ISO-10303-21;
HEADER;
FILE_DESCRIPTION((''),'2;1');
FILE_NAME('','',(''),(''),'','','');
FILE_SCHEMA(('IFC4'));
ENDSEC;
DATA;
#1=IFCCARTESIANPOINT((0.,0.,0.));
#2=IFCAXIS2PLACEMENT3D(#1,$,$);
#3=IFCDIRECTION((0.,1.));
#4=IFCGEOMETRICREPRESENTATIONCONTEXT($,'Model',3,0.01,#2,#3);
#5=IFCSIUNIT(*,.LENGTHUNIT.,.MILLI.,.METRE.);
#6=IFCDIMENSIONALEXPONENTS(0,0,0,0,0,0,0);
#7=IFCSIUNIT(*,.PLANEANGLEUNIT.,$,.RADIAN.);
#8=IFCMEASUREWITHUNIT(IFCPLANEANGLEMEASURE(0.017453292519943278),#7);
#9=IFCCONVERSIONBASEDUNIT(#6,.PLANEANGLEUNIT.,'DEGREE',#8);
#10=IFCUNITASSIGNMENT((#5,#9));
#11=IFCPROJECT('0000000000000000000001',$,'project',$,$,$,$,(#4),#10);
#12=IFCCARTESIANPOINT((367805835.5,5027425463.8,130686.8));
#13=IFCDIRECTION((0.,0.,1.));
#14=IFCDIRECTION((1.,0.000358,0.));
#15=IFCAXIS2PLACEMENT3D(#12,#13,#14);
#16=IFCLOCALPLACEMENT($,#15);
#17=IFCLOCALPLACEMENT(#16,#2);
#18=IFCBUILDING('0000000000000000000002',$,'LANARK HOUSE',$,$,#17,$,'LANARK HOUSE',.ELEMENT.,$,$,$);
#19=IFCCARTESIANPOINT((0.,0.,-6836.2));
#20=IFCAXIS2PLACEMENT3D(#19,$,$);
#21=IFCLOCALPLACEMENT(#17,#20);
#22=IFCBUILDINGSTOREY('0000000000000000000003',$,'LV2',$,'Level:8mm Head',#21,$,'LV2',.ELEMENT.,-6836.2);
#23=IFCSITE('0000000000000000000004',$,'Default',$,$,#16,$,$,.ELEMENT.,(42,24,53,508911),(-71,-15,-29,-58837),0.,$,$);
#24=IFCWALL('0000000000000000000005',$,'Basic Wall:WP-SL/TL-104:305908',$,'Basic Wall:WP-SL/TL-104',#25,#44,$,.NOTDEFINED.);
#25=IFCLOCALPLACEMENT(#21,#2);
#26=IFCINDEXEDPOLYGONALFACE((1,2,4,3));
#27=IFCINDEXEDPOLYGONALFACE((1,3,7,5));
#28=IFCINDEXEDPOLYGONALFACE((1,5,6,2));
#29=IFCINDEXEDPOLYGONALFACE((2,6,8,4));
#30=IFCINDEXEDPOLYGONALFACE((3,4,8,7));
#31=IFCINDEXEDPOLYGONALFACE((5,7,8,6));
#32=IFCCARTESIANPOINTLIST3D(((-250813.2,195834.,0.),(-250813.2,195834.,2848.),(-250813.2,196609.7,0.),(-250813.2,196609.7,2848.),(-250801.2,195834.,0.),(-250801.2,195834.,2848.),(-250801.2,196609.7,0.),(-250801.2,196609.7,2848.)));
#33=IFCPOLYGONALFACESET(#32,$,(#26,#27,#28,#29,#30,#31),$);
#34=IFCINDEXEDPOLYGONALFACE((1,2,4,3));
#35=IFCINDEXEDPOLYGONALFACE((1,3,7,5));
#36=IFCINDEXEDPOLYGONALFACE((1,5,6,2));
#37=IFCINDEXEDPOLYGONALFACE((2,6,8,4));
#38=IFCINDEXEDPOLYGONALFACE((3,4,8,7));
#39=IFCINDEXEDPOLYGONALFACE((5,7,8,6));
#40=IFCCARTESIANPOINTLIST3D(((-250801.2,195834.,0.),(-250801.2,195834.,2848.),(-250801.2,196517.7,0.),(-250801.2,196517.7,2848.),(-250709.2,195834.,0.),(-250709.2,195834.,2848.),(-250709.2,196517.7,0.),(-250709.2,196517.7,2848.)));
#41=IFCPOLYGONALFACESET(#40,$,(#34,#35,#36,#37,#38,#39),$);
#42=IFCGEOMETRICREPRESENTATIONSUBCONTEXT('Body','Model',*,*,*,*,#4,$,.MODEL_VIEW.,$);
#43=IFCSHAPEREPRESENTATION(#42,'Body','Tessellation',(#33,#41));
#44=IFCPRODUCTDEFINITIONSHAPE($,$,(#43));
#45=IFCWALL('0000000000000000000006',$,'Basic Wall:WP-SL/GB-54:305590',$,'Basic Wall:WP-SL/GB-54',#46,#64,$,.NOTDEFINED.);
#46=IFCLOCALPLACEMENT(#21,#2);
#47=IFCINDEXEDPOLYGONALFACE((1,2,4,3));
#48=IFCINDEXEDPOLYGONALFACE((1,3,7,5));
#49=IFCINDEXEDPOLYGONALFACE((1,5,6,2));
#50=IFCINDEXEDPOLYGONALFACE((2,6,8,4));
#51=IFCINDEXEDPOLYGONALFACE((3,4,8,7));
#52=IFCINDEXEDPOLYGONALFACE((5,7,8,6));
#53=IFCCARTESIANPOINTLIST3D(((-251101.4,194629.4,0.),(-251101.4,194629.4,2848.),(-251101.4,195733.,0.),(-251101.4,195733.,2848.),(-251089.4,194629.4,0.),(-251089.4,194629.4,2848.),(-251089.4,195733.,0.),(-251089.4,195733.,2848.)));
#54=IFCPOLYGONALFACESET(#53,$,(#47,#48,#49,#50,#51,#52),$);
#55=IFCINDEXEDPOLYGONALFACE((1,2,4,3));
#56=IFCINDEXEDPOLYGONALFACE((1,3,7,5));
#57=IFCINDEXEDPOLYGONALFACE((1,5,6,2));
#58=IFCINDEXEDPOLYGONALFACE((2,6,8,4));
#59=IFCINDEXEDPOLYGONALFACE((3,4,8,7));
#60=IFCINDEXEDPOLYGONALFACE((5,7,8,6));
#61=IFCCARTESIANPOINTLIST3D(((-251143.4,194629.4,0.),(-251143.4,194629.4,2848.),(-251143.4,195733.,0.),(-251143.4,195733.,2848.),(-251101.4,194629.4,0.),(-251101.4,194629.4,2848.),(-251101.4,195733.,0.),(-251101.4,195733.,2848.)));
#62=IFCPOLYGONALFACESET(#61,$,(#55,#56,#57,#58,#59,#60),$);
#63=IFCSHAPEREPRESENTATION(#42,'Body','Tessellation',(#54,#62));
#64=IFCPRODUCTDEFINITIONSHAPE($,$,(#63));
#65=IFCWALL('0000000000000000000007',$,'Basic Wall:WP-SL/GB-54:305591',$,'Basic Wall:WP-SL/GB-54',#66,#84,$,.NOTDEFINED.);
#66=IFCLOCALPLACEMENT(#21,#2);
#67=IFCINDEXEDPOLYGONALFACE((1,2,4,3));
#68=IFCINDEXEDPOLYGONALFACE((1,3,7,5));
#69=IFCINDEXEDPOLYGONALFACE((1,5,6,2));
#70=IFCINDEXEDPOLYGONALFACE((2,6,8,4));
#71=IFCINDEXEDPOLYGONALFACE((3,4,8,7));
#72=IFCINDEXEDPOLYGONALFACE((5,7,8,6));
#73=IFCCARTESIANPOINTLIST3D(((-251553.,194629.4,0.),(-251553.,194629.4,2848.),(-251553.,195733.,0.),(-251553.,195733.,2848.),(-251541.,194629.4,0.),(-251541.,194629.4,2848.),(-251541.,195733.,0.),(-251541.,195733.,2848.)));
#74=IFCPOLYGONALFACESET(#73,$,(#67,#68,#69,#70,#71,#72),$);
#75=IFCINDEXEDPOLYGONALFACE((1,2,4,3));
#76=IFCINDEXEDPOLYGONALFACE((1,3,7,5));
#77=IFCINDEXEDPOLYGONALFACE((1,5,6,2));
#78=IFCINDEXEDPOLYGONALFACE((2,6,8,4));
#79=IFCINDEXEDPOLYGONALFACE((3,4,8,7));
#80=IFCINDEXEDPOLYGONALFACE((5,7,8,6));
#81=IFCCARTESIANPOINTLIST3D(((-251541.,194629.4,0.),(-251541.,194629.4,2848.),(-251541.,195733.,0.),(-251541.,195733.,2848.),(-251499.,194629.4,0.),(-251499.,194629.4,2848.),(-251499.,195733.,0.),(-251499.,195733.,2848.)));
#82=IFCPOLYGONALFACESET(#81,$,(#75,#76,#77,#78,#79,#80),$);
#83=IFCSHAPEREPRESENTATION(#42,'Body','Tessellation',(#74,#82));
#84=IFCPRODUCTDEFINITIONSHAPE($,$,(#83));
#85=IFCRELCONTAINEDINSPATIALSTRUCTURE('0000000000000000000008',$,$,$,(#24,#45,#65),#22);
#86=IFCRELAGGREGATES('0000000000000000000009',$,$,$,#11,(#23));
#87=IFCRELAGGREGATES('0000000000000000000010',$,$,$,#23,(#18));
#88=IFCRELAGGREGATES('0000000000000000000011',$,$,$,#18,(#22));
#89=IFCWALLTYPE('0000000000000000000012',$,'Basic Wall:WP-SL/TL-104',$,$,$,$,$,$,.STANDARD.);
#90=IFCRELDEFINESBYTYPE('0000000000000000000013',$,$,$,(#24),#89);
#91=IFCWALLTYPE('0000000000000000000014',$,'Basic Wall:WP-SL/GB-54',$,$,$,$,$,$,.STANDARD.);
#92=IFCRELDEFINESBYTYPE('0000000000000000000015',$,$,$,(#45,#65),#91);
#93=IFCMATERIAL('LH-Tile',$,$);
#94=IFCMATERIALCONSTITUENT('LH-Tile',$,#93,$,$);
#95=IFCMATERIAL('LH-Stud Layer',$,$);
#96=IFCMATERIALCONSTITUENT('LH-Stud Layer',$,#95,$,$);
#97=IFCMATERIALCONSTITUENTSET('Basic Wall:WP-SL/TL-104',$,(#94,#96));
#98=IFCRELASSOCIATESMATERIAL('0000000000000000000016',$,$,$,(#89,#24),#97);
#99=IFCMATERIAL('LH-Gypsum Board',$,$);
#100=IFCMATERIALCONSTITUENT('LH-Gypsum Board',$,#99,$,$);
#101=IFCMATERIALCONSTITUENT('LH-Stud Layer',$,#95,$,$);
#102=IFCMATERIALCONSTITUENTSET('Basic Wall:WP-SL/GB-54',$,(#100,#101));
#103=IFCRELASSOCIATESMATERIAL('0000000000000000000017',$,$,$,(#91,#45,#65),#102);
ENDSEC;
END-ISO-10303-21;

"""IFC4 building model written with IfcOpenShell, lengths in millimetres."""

from ifc_helpers import new_model, entity, si_unit, converted_unit, direction, frame, origin, place, context, subcontext, project, spatial, indexed_curve, outline, extrude, material, constituent, constituent_set, type_object, element, save


model = new_model("IFC4")

# Units and contexts
model_context = context("Model", 3, precision=0.01, world=origin(), true_north=direction((0.0, 1.0)))
body_context = subcontext(model_context, "Body", "Model", "MODEL_VIEW")
ifc_project = project(units=[si_unit("LENGTHUNIT", "METRE", prefix="MILLI"), converted_unit("PLANEANGLEUNIT", "DEGREE", entity("IfcPlaneAngleMeasure", 0.017453292519943278), si_unit("PLANEANGLEUNIT", "RADIAN"), dimensions=[0, 0, 0, 0, 0, 0, 0])], contexts=[model_context])

# Site, building, storey
site_placement = place(None, frame((367805835.5, 5027425463.8, 130686.8), z_axis=(0.0, 0.0, 1.0), x_axis=(1.0, 0.000358, 0.0)))
site = spatial("IfcSite", under=ifc_project, at=site_placement, Name="Default", CompositionType="ELEMENT", RefLatitude=(42, 24, 53, 508911), RefLongitude=(-71, -15, -29, -58837), RefElevation=0.0)
building_placement = place(site_placement, origin())
building = spatial("IfcBuilding", under=site, at=building_placement, Name="LANARK HOUSE", LongName="LANARK HOUSE", CompositionType="ELEMENT")
storey_placement = place(building_placement, frame((0.0, 0.0, -6836.2)))
storey = spatial("IfcBuildingStorey", under=building, at=storey_placement, Name="LV2", ObjectType="Level:8mm Head", LongName="LV2", CompositionType="ELEMENT", Elevation=-6836.2)

# Walls
ifc_material_1 = material(Name="LH-Tile")
ifc_constituent_1 = constituent(ifc_material_1, Name="LH-Tile")
ifc_material_2 = material(Name="LH-Stud Layer")
ifc_constituent_2 = constituent(ifc_material_2, Name="LH-Stud Layer")
ifc_constituent_set_1 = constituent_set(constituents=[ifc_constituent_1, ifc_constituent_2], Name="Basic Wall:WP-SL/TL-104")
wall_type_1 = type_object("IfcWallType", Name="Basic Wall:WP-SL/TL-104", PredefinedType="STANDARD", material=ifc_constituent_set_1)
wall_1_placement = place(storey_placement, frame((-250761.2, 195834.0, 0.0), z_axis=(0.0, 0.0, 1.0), x_axis=(0.0, 1.0, 0.0)))
element("IfcWall", 1, at=wall_1_placement, inside=storey, type_object=wall_type_1, material=ifc_constituent_set_1, Name="Basic Wall:WP-SL/TL-104:305908", ObjectType="Basic Wall:WP-SL/TL-104", PredefinedType="NOTDEFINED", context=body_context, shape_type="SweptSolid", body=[
    extrude(outline(indexed_curve([(-6.0, -387.8), (6.0, -387.8), (6.0, 387.8), (-6.0, 387.8), (-6.0, -387.8)], self_intersect=False)), frame((387.8, 46.0, 0.0), z_axis=(0.0, 0.0, 1.0), x_axis=(0.0, -1.0, 0.0)), (0.0, 0.0, 1.0), 2848.0),
    extrude(outline(indexed_curve([(-46.0, -341.8), (46.0, -341.8), (46.0, 341.8), (-46.0, 341.8), (-46.0, -341.8)], self_intersect=False)), frame((341.8, -6.0, 0.0), z_axis=(0.0, 0.0, 1.0), x_axis=(0.0, 1.0, 0.0)), (0.0, 0.0, 1.0), 2848.0),
])
ifc_material_3 = material(Name="LH-Gypsum Board")
ifc_constituent_3 = constituent(ifc_material_3, Name="LH-Gypsum Board")
ifc_constituent_4 = constituent(ifc_material_2, Name="LH-Stud Layer")
ifc_constituent_set_2 = constituent_set(constituents=[ifc_constituent_3, ifc_constituent_4], Name="Basic Wall:WP-SL/GB-54")
wall_type_2 = type_object("IfcWallType", Name="Basic Wall:WP-SL/GB-54", PredefinedType="STANDARD", material=ifc_constituent_set_2)
wall_2_placement = place(storey_placement, frame((-251116.4, 195733.0, 0.0), z_axis=(0.0, 0.0, 1.0), x_axis=(0.0, -1.0, 0.0)))
element("IfcWall", 2, at=wall_2_placement, inside=storey, type_object=wall_type_2, material=ifc_constituent_set_2, Name="Basic Wall:WP-SL/GB-54:305590", ObjectType="Basic Wall:WP-SL/GB-54", PredefinedType="NOTDEFINED", context=body_context, shape_type="SweptSolid", body=[
    extrude(outline(indexed_curve([(-6.0, -551.8), (6.0, -551.8), (6.0, 551.8), (-6.0, 551.8), (-6.0, -551.8)], self_intersect=False)), frame((551.8, 21.0, 0.0), z_axis=(0.0, 0.0, 1.0), x_axis=(0.0, -1.0, 0.0)), (0.0, 0.0, 1.0), 2848.0),
    extrude(outline(indexed_curve([(-21.0, -551.8), (21.0, -551.8), (21.0, 551.8), (-21.0, 551.8), (-21.0, -551.8)], self_intersect=False)), frame((551.8, -6.0, 0.0), z_axis=(0.0, 0.0, 1.0), x_axis=(0.0, 1.0, 0.0)), (0.0, 0.0, 1.0), 2848.0),
])
wall_3_placement = place(storey_placement, frame((-251526.0, 194629.4, 0.0), z_axis=(0.0, 0.0, 1.0), x_axis=(0.0, 1.0, 0.0)))
element("IfcWall", 3, at=wall_3_placement, inside=storey, type_object=wall_type_2, material=ifc_constituent_set_2, Name="Basic Wall:WP-SL/GB-54:305591", ObjectType="Basic Wall:WP-SL/GB-54", PredefinedType="NOTDEFINED", context=body_context, shape_type="SweptSolid", body=[
    extrude(outline(indexed_curve([(-6.0, -551.8), (6.0, -551.8), (6.0, 551.8), (-6.0, 551.8), (-6.0, -551.8)], self_intersect=False)), frame((551.8, 21.0, 0.0), z_axis=(0.0, 0.0, 1.0), x_axis=(0.0, -1.0, 0.0)), (0.0, 0.0, 1.0), 2848.0),
    extrude(outline(indexed_curve([(-21.0, -551.8), (21.0, -551.8), (21.0, 551.8), (-21.0, 551.8), (-21.0, -551.8)], self_intersect=False)), frame((551.8, -6.0, 0.0), z_axis=(0.0, 0.0, 1.0), x_axis=(0.0, 1.0, 0.0)), (0.0, 0.0, 1.0), 2848.0),
])

save(model, "model.ifc")
